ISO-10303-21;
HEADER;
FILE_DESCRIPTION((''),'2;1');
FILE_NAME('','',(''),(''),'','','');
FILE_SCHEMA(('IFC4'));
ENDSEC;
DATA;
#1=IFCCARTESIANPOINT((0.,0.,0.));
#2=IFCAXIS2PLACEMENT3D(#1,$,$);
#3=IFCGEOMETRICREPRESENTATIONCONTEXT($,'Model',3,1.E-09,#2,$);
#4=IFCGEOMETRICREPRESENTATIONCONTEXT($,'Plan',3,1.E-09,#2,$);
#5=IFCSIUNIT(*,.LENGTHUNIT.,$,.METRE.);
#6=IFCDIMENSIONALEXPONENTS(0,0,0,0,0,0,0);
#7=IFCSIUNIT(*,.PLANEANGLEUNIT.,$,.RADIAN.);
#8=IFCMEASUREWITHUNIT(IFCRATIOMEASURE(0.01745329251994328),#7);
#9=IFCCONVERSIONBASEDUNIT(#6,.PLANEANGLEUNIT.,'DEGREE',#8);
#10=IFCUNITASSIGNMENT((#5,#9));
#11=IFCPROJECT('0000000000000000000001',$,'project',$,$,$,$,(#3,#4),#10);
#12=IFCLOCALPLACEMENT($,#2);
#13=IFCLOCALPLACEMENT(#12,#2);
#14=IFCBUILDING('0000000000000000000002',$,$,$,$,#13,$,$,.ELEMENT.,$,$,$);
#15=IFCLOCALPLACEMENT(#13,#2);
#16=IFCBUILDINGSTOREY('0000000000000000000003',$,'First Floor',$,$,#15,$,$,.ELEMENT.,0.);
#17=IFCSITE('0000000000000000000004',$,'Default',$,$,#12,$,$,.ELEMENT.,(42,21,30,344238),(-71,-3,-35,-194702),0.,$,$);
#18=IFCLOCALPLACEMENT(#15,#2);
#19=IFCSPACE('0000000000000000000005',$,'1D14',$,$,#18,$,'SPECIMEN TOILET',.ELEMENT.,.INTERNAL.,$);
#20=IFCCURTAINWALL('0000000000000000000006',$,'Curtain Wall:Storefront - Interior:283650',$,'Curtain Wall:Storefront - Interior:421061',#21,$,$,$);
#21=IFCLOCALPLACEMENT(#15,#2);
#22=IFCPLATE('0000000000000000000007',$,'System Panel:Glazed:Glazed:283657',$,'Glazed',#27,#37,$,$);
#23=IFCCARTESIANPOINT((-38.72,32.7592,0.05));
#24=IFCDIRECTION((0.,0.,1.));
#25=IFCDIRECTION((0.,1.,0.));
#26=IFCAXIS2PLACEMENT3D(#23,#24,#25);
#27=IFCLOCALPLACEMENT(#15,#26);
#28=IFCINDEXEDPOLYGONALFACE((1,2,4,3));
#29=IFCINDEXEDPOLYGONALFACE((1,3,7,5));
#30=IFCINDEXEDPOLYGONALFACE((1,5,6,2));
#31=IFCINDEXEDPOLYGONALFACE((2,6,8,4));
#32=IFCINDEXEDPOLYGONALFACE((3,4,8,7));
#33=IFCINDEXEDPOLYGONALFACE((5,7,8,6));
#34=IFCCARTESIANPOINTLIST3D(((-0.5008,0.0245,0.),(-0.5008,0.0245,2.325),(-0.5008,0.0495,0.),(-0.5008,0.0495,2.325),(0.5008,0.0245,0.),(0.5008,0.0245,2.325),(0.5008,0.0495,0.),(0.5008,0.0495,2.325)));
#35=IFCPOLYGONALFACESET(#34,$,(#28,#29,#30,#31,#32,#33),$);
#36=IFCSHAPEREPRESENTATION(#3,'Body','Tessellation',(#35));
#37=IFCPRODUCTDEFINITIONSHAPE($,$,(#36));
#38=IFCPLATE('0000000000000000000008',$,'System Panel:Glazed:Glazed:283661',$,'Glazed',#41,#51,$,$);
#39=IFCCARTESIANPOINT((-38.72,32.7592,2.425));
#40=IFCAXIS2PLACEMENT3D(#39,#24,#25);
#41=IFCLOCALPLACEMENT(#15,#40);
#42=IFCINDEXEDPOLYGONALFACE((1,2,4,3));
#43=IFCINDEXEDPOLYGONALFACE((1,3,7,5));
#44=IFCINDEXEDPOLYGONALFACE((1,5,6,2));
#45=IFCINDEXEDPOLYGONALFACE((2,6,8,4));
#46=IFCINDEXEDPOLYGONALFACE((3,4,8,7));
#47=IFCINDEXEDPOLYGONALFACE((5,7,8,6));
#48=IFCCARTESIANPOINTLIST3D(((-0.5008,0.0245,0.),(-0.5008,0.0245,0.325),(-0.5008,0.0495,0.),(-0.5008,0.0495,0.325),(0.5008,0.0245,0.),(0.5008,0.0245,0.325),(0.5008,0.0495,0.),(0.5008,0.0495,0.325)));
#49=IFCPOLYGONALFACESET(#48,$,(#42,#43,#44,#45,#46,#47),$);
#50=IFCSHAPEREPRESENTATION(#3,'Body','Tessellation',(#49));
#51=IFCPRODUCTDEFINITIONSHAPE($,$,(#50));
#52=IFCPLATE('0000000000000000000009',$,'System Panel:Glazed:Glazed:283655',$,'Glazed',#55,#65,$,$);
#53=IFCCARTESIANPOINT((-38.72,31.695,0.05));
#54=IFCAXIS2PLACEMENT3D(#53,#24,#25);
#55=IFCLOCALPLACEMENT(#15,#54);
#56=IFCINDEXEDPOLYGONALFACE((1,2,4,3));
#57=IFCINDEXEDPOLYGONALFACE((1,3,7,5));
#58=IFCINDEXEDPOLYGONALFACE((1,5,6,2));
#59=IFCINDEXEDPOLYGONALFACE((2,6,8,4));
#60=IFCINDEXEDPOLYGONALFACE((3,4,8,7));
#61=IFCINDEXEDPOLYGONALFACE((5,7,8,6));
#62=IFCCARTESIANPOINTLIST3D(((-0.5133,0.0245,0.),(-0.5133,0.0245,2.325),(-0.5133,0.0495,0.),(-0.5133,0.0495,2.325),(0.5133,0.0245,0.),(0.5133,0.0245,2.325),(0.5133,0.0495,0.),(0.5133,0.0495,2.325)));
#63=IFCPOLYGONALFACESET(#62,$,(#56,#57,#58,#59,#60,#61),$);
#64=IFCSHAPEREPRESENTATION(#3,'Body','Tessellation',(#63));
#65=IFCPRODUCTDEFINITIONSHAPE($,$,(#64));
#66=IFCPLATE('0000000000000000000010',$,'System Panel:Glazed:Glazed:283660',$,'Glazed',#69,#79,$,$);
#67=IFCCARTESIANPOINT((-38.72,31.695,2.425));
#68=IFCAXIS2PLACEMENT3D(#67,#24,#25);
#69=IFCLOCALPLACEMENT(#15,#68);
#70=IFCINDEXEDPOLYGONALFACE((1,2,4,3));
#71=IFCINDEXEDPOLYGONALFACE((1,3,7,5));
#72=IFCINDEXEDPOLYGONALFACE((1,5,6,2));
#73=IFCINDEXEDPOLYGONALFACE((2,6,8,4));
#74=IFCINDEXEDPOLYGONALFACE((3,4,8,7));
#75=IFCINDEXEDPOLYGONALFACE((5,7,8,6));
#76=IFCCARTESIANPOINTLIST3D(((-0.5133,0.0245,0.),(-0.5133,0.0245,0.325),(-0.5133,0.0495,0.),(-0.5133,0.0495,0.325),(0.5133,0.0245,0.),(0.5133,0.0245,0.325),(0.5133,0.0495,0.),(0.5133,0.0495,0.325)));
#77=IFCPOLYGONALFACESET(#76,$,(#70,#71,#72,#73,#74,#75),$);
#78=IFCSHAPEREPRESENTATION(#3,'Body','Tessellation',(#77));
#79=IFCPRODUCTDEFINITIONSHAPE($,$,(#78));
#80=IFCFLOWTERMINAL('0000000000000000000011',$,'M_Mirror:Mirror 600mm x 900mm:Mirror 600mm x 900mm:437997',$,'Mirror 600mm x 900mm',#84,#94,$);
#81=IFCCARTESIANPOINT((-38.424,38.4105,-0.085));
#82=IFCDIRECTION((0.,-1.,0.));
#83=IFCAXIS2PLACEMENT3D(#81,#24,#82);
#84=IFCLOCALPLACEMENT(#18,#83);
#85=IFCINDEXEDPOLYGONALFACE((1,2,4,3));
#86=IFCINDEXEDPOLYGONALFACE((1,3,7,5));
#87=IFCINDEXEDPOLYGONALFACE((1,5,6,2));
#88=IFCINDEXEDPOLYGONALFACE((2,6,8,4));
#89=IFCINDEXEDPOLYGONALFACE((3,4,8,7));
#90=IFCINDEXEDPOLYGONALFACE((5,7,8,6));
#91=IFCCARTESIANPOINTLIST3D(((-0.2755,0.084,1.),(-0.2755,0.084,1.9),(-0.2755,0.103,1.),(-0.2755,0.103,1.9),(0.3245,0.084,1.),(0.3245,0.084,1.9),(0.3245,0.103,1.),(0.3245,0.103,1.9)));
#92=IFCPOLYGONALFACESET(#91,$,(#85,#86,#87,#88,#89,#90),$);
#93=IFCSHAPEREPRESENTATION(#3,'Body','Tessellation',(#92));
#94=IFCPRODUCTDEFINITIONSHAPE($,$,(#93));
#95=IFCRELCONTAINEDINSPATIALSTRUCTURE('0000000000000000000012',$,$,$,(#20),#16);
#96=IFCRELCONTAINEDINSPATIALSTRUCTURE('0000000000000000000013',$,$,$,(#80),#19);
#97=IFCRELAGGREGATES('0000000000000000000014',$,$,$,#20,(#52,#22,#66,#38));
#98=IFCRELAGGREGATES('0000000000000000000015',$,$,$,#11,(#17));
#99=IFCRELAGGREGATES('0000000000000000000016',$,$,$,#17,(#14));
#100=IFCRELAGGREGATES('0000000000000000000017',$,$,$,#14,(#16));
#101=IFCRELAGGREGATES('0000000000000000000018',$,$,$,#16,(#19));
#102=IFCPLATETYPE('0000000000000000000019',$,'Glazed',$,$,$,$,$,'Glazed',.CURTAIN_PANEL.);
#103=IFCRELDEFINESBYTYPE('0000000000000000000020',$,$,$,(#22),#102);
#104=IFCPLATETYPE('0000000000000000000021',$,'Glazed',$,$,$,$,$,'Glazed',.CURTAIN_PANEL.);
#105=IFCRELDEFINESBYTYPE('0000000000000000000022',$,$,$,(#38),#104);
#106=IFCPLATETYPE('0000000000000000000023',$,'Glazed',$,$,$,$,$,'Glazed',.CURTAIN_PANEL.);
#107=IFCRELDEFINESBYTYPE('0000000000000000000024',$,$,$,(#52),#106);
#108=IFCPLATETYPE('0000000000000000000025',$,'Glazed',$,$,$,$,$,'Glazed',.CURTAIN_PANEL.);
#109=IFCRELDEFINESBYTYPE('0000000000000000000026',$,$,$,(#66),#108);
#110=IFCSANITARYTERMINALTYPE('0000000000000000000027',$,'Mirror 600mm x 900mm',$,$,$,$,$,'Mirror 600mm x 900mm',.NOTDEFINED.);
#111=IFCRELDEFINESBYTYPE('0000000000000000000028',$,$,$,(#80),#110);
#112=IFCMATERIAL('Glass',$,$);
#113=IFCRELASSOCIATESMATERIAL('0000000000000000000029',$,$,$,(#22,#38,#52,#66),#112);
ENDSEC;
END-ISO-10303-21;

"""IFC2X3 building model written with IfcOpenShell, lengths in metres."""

from ifc_helpers import new_model, entity, si_unit, converted_unit, frame, origin, origin_2d_with_axis, place, context, project, spatial, rectangle, extrude, source, transform, mapped, material, type_object, type_shapes, element, aggregate, save


model = new_model("IFC2X3")

# Units and contexts
model_context = context("Model", 3, precision=1e-09, world=origin())
plan_context = context("Plan", 3, precision=1e-09, world=origin())
ifc_project = project(units=[si_unit("LENGTHUNIT", "METRE"), converted_unit("PLANEANGLEUNIT", "DEGREE", entity("IfcRatioMeasure", 0.01745329251994328), si_unit("PLANEANGLEUNIT", "RADIAN"), dimensions=[0, 0, 0, 0, 0, 0, 0])], contexts=[model_context, plan_context])

# Site, building, storey
site_placement = place(None, origin())
site = spatial("IfcSite", under=ifc_project, at=site_placement, Name="Default", CompositionType="ELEMENT", RefLatitude=(42, 21, 30, 344238), RefLongitude=(-71, -3, -35, -194702), RefElevation=0.0)
building_placement = place(site_placement, origin())
building = spatial("IfcBuilding", under=site, at=building_placement, CompositionType="ELEMENT")
storey_placement = place(building_placement, origin())
storey = spatial("IfcBuildingStorey", under=building, at=storey_placement, Name="First Floor", CompositionType="ELEMENT", Elevation=0.0)

# Curtain wall
curtain_wall_1_placement = place(storey_placement, origin())
curtain_wall_1 = element("IfcCurtainWall", 1, at=curtain_wall_1_placement, inside=storey, Name="Curtain Wall:Storefront - Interior:283650", ObjectType="Curtain Wall:Storefront - Interior:421061")

# Plates
ifc_material_1 = material(Name="Glass")
plate_type_1 = type_object("IfcPlateType", Name="Glazed", ElementType="Glazed", PredefinedType="CURTAIN_PANEL")
shared_shape_1 = source(origin(), model_context, "Body", "SweptSolid", [
    extrude(rectangle(XDim=0.025, YDim=1.0017, at=origin_2d_with_axis()), frame((0.0, 0.037, 0.0), z_axis=(0.0, 0.0, 1.0), x_axis=(0.0, 1.0, 0.0)), (0.0, 0.0, 1.0), 2.325),
])
type_shapes(plate_type_1, [shared_shape_1])
plate_1_placement = place(storey_placement, frame((-38.72, 32.7592, 0.05), z_axis=(0.0, 0.0, 1.0), x_axis=(0.0, 1.0, 0.0)))
plate_1 = element("IfcPlate", 2, at=plate_1_placement, type_object=plate_type_1, material=ifc_material_1, Name="System Panel:Glazed:Glazed:283657", ObjectType="Glazed", context=model_context, shape_type="MappedRepresentation", body=[
    mapped(shared_shape_1, transform((0.0, 0.0, 0.0), scale=1.0)),
])
plate_type_2 = type_object("IfcPlateType", Name="Glazed", ElementType="Glazed", PredefinedType="CURTAIN_PANEL")
shared_shape_2 = source(origin(), model_context, "Body", "SweptSolid", [
    extrude(rectangle(XDim=0.025, YDim=1.0017, at=origin_2d_with_axis()), frame((0.0, 0.037, 0.0), z_axis=(0.0, 0.0, 1.0), x_axis=(0.0, 1.0, 0.0)), (0.0, 0.0, 1.0), 0.325),
])
type_shapes(plate_type_2, [shared_shape_2])
plate_2_placement = place(storey_placement, frame((-38.72, 32.7592, 2.425), z_axis=(0.0, 0.0, 1.0), x_axis=(0.0, 1.0, 0.0)))
plate_2 = element("IfcPlate", 3, at=plate_2_placement, type_object=plate_type_2, material=ifc_material_1, Name="System Panel:Glazed:Glazed:283661", ObjectType="Glazed", context=model_context, shape_type="MappedRepresentation", body=[
    mapped(shared_shape_2, transform((0.0, 0.0, 0.0), scale=1.0)),
])
plate_type_3 = type_object("IfcPlateType", Name="Glazed", ElementType="Glazed", PredefinedType="CURTAIN_PANEL")
shared_shape_3 = source(origin(), model_context, "Body", "SweptSolid", [
    extrude(rectangle(XDim=0.025, YDim=1.0267, at=origin_2d_with_axis()), frame((0.0, 0.037, 0.0), z_axis=(0.0, 0.0, 1.0), x_axis=(0.0, 1.0, 0.0)), (0.0, 0.0, 1.0), 2.325),
])
type_shapes(plate_type_3, [shared_shape_3])
plate_3_placement = place(storey_placement, frame((-38.72, 31.695, 0.05), z_axis=(0.0, 0.0, 1.0), x_axis=(0.0, 1.0, 0.0)))
plate_3 = element("IfcPlate", 4, at=plate_3_placement, type_object=plate_type_3, material=ifc_material_1, Name="System Panel:Glazed:Glazed:283655", ObjectType="Glazed", context=model_context, shape_type="MappedRepresentation", body=[
    mapped(shared_shape_3, transform((0.0, 0.0, 0.0), scale=1.0)),
])
plate_type_4 = type_object("IfcPlateType", Name="Glazed", ElementType="Glazed", PredefinedType="CURTAIN_PANEL")
shared_shape_4 = source(origin(), model_context, "Body", "SweptSolid", [
    extrude(rectangle(XDim=0.025, YDim=1.0267, at=origin_2d_with_axis()), frame((0.0, 0.037, 0.0), z_axis=(0.0, 0.0, 1.0), x_axis=(0.0, 1.0, 0.0)), (0.0, 0.0, 1.0), 0.325),
])
type_shapes(plate_type_4, [shared_shape_4])
plate_4_placement = place(storey_placement, frame((-38.72, 31.695, 2.425), z_axis=(0.0, 0.0, 1.0), x_axis=(0.0, 1.0, 0.0)))
plate_4 = element("IfcPlate", 5, at=plate_4_placement, type_object=plate_type_4, material=ifc_material_1, Name="System Panel:Glazed:Glazed:283660", ObjectType="Glazed", context=model_context, shape_type="MappedRepresentation", body=[
    mapped(shared_shape_4, transform((0.0, 0.0, 0.0), scale=1.0)),
])
aggregate(curtain_wall_1, [plate_3, plate_1, plate_4, plate_2])

# Shared definitions
space_placement = place(storey_placement, origin())
space = spatial("IfcSpace", under=storey, at=space_placement, Name="1D14", LongName="SPECIMEN TOILET", CompositionType="ELEMENT", InteriorOrExteriorSpace="INTERNAL")

# Flow terminal
sanitary_terminal_type = type_object("IfcSanitaryTerminalType", Name="Mirror 600mm x 900mm", ElementType="Mirror 600mm x 900mm", PredefinedType="NOTDEFINED")
shared_shape_5 = source(origin(), model_context, "Body", "SweptSolid", [
    extrude(rectangle(XDim=0.0191, YDim=0.6, at=origin_2d_with_axis()), frame((0.0245, 0.0935, 1.0), z_axis=(0.0, 0.0, 1.0), x_axis=(0.0, -1.0, 0.0)), (0.0, 0.0, 1.0), 0.9),
])
type_shapes(sanitary_terminal_type, [shared_shape_5])
flow_terminal_placement = place(space_placement, frame((-38.424, 38.4105, -0.085), z_axis=(0.0, 0.0, 1.0), x_axis=(0.0, -1.0, 0.0)))
element("IfcFlowTerminal", 6, at=flow_terminal_placement, inside=space, type_object=sanitary_terminal_type, Name="M_Mirror:Mirror 600mm x 900mm:Mirror 600mm x 900mm:437997", ObjectType="Mirror 600mm x 900mm", context=model_context, shape_type="MappedRepresentation", body=[
    mapped(shared_shape_5, transform((0.0, 0.0, 0.0), scale=1.0)),
])

save(model, "model.ifc")
